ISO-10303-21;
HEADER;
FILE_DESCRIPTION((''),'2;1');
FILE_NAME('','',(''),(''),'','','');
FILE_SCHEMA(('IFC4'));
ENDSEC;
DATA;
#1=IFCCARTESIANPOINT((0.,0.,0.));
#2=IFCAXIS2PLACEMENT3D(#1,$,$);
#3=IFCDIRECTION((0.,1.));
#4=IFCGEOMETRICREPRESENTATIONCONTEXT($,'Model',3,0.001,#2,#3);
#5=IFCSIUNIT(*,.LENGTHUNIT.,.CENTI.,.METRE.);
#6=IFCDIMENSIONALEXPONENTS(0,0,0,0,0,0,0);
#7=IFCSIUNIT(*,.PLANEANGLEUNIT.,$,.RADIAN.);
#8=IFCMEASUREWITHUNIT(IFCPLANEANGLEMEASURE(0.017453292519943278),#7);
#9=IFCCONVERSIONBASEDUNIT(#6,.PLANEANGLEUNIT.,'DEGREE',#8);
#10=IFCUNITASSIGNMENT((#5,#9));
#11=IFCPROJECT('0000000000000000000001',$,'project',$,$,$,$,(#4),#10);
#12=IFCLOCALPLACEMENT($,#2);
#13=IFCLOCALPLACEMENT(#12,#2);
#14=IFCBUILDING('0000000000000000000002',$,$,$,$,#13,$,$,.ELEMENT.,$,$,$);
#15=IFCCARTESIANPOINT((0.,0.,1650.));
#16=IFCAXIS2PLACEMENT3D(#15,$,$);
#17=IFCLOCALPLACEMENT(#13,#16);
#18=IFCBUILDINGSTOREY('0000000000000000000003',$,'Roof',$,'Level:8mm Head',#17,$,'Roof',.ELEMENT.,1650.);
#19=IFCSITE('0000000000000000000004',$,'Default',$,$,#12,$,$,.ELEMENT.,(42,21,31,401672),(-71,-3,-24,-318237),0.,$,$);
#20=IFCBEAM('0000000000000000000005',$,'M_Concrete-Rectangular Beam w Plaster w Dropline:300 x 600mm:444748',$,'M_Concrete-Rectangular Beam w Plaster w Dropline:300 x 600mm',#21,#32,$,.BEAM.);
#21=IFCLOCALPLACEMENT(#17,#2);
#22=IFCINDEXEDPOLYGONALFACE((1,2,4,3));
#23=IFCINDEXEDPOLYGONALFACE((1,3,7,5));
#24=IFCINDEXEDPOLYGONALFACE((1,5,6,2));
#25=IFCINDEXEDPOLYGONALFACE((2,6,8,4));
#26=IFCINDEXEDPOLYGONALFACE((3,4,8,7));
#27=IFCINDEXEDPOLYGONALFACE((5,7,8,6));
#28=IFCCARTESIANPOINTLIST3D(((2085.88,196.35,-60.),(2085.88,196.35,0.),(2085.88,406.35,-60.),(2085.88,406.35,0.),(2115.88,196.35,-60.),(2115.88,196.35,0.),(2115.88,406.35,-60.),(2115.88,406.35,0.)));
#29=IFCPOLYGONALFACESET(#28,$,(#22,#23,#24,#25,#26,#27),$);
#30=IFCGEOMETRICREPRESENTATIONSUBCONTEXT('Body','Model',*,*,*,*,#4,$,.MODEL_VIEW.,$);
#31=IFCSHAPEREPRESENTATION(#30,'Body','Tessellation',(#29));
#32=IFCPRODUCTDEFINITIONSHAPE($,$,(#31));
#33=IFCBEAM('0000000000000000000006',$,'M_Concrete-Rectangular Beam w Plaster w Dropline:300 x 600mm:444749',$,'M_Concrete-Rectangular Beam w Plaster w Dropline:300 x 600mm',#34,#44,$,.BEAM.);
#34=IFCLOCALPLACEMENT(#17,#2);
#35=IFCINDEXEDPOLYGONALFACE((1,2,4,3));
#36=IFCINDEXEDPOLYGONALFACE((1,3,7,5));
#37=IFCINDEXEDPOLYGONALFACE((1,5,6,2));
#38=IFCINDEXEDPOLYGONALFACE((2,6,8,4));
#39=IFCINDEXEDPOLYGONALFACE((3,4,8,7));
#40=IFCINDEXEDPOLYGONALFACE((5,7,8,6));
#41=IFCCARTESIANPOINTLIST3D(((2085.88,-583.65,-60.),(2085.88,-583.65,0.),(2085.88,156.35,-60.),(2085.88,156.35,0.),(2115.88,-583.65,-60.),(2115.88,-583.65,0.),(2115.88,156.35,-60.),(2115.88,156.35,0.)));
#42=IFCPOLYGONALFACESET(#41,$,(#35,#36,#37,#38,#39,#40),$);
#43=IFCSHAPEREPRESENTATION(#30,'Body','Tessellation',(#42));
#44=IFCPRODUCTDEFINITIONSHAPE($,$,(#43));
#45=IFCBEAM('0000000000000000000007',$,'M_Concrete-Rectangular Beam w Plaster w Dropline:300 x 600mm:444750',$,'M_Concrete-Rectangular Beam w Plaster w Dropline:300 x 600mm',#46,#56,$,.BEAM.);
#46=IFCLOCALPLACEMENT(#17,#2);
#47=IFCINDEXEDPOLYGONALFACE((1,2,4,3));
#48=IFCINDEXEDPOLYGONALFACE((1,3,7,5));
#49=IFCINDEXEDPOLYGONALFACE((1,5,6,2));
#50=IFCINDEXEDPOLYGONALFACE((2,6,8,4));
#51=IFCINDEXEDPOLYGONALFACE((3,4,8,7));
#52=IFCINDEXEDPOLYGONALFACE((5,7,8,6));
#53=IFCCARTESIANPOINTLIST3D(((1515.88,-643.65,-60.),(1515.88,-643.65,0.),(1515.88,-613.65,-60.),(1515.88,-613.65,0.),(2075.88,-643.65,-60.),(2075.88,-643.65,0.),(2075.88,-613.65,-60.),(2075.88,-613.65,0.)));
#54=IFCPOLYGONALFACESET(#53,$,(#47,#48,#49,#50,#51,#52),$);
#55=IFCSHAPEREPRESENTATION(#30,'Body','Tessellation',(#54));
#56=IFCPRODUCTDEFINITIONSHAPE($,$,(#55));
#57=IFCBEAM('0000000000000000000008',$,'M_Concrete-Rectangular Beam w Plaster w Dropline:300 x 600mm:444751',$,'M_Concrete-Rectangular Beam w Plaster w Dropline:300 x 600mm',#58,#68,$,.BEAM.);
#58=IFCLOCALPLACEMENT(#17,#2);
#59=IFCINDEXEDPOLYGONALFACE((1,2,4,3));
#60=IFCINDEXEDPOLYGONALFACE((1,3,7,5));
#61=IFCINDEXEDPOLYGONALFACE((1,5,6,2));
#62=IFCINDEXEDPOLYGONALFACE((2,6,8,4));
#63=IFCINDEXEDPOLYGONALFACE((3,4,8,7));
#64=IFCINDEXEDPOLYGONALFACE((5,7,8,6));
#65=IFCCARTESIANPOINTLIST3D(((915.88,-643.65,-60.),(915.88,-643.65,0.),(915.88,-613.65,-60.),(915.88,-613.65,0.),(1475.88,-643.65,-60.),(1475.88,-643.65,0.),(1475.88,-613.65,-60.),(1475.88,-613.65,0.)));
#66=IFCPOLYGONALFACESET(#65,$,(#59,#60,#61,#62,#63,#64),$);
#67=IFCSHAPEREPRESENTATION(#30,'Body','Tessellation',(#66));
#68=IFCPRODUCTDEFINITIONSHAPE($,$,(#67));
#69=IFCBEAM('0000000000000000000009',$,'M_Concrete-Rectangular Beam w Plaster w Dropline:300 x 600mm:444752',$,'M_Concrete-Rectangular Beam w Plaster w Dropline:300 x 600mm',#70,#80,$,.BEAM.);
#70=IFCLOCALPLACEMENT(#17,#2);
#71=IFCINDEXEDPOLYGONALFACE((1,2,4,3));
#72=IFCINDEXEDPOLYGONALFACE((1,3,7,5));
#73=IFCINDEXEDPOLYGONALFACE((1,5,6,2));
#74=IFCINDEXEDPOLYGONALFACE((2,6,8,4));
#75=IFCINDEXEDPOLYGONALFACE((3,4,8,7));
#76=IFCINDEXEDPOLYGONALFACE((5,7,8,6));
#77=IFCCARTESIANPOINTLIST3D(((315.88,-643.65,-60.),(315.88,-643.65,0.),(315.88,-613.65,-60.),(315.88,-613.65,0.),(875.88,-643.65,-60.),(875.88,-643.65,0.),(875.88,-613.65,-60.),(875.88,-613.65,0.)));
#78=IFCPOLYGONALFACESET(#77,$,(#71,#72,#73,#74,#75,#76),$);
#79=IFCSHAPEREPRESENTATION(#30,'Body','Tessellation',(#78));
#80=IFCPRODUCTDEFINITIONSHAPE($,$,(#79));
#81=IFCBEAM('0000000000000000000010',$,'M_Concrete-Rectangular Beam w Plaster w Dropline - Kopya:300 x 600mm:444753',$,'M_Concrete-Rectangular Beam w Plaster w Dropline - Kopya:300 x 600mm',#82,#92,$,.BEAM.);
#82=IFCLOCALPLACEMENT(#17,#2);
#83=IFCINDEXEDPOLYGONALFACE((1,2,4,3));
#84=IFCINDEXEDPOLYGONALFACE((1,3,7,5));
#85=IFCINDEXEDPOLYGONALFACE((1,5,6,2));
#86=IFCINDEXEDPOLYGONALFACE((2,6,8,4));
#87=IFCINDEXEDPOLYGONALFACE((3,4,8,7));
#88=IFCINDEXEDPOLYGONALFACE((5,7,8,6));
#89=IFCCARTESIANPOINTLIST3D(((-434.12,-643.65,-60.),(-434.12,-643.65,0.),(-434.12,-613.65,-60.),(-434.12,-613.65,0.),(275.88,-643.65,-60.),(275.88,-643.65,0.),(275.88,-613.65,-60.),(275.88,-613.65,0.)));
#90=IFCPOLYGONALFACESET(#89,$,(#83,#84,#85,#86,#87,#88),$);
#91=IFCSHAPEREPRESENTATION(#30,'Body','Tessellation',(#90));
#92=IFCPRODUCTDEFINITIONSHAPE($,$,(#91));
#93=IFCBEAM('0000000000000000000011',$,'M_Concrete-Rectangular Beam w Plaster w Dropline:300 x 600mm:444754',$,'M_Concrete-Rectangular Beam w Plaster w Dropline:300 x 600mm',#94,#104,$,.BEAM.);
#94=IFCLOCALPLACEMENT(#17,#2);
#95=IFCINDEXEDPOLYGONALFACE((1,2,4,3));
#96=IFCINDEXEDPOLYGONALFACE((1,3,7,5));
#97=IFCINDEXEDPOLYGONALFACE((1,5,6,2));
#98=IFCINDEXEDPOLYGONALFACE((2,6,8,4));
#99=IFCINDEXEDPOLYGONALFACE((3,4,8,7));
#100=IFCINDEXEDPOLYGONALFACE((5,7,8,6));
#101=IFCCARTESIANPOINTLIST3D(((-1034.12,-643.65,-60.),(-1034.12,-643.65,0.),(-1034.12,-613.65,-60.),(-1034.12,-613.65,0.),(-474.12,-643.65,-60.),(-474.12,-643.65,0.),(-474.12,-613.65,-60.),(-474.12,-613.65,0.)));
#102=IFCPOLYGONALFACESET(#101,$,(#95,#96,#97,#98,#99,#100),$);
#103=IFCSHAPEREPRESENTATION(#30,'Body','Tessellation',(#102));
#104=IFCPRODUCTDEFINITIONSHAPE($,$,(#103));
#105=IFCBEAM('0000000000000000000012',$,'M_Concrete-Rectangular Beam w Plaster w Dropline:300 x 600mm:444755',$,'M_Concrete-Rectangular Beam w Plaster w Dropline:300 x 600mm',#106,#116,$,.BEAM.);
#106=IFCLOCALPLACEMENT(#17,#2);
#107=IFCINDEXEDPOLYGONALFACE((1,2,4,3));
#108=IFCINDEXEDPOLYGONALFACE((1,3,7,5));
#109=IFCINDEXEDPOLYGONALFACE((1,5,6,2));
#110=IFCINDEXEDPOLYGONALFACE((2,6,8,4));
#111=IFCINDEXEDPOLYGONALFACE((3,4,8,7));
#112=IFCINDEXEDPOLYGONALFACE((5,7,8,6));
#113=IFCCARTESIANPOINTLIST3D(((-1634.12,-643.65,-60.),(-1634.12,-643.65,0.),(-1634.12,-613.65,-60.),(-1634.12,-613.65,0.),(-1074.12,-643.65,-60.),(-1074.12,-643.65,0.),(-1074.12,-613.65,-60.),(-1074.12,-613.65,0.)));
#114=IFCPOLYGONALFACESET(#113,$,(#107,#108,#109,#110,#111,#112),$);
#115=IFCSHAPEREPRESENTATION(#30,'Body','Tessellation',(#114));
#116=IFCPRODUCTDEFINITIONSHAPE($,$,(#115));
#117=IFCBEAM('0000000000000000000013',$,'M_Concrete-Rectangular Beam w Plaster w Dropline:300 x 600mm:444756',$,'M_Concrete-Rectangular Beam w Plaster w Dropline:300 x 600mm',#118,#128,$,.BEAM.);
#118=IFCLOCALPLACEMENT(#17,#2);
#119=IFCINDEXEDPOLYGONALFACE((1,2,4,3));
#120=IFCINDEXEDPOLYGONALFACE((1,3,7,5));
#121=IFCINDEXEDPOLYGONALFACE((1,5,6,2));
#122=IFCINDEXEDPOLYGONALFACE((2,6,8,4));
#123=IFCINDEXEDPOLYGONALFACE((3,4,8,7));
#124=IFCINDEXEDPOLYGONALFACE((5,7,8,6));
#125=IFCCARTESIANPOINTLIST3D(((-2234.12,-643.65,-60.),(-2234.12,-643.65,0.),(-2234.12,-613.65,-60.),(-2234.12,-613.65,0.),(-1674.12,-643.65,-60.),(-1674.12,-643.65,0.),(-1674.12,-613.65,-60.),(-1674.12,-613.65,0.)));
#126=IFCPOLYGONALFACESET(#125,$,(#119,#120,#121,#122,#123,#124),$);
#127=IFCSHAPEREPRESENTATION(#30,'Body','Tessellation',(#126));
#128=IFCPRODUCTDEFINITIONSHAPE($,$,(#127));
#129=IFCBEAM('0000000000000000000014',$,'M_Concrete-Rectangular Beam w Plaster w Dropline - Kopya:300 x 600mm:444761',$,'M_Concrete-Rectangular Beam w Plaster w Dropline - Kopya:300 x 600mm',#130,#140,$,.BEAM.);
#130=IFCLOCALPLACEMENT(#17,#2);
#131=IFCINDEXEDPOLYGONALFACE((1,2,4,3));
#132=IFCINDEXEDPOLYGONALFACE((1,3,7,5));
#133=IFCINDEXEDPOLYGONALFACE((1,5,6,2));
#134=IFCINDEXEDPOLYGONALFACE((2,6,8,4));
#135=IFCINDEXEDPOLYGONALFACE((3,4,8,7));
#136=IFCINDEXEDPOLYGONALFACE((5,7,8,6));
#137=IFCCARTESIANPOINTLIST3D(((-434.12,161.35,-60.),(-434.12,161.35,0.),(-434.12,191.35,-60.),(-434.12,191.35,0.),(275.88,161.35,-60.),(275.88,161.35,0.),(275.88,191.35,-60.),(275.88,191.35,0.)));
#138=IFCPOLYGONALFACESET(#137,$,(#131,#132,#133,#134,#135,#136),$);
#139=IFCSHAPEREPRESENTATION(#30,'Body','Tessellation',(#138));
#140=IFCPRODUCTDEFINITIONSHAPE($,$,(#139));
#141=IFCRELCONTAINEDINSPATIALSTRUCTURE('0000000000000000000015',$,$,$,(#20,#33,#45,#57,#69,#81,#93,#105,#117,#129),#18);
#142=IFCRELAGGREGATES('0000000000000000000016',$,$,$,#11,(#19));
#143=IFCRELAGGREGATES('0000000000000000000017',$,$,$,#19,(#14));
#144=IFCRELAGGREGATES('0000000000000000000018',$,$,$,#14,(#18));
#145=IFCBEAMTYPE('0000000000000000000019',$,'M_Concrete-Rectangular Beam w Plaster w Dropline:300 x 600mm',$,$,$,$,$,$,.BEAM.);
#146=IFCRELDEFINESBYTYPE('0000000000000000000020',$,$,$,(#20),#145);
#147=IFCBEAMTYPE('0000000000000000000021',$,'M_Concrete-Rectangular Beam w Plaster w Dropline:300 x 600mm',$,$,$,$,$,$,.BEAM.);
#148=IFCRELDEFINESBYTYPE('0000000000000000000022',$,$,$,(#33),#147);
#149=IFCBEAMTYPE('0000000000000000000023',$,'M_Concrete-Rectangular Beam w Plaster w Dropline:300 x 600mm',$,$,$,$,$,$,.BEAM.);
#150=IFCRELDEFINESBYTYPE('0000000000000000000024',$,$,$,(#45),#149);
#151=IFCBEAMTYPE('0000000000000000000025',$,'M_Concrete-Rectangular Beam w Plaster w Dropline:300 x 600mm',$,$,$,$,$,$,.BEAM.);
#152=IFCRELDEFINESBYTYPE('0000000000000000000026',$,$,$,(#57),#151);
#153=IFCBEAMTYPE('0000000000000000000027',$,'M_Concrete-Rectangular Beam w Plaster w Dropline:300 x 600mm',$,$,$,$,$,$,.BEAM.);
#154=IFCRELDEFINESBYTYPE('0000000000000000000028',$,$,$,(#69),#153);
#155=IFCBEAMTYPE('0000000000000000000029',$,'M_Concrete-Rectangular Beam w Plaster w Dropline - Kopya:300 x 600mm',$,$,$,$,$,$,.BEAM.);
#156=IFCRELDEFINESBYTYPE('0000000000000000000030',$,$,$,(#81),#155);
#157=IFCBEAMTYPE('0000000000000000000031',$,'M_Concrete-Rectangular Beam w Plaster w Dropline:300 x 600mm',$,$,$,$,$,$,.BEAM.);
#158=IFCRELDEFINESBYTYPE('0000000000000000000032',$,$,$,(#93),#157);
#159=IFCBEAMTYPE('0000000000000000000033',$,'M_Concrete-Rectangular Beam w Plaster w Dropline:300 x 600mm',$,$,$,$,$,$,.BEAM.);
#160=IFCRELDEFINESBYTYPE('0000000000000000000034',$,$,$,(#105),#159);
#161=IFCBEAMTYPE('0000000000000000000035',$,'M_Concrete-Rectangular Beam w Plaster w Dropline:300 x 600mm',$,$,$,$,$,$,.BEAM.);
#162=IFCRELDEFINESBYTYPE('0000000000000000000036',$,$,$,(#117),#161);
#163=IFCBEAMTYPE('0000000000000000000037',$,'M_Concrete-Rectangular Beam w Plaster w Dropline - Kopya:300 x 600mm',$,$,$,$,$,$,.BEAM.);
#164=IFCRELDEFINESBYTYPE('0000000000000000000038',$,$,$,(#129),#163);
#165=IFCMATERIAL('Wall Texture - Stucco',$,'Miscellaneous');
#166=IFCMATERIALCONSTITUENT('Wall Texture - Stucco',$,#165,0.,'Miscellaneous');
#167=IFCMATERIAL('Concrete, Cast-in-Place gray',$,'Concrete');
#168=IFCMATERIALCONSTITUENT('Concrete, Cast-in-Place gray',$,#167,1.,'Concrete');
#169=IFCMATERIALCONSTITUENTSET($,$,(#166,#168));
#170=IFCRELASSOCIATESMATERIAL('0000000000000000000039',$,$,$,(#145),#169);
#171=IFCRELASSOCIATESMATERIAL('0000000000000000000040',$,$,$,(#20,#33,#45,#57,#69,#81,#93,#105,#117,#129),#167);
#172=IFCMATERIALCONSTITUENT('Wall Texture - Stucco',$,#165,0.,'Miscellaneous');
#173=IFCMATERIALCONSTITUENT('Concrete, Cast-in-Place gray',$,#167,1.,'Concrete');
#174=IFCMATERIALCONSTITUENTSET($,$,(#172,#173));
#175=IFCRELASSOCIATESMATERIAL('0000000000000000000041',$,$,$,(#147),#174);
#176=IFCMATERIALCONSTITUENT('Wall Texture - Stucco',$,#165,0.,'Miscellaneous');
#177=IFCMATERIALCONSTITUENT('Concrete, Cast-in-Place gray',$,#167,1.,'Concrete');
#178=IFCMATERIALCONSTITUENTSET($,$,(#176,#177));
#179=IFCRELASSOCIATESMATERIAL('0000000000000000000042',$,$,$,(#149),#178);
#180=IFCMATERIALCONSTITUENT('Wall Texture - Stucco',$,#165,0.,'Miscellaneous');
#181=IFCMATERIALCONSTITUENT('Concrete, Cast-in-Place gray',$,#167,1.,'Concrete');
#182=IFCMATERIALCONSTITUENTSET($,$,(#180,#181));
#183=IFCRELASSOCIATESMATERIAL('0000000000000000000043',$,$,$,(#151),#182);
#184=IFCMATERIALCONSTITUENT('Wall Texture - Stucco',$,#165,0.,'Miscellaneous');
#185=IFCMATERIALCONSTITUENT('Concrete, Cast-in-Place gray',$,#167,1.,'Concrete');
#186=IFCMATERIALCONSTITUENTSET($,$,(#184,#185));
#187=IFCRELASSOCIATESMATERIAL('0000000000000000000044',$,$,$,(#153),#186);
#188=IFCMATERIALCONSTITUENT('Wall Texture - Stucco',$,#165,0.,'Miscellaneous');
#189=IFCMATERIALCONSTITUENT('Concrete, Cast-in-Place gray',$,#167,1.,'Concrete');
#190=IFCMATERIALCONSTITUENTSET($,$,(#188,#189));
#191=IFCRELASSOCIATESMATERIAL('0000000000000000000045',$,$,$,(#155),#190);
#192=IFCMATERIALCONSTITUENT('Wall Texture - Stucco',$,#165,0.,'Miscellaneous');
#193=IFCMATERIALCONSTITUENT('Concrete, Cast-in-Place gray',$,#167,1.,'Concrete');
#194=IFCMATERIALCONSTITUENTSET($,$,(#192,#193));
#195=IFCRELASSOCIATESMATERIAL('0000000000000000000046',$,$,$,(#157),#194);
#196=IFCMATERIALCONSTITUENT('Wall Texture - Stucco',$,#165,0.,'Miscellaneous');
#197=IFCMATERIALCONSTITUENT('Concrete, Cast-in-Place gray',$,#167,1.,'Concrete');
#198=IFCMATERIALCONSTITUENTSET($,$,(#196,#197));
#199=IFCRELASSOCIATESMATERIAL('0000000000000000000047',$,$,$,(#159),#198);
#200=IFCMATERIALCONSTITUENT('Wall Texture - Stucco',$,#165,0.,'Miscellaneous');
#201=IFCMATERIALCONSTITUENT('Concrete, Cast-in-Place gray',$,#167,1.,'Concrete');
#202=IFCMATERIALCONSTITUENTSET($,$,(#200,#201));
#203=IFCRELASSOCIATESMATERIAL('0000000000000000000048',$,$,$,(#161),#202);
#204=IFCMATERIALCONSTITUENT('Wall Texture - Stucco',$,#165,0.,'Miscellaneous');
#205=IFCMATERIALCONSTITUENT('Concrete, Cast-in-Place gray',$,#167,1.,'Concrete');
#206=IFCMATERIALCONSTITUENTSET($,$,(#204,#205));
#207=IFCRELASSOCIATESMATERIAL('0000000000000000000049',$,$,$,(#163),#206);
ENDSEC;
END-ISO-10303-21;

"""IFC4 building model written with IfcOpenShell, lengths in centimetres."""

from ifc_helpers import new_model, entity, si_unit, converted_unit, direction, frame, origin, place, context, subcontext, project, spatial, indexed_curve, outline, extrude, source, transform, mapped, material, constituent, constituent_set, type_object, type_shapes, element, save


model = new_model("IFC4")

# Units and contexts
model_context = context("Model", 3, precision=0.001, world=origin(), true_north=direction((0.0, 1.0)))
body_context = subcontext(model_context, "Body", "Model", "MODEL_VIEW")
ifc_project = project(units=[si_unit("LENGTHUNIT", "METRE", prefix="CENTI"), converted_unit("PLANEANGLEUNIT", "DEGREE", entity("IfcPlaneAngleMeasure", 0.017453292519943278), si_unit("PLANEANGLEUNIT", "RADIAN"), dimensions=[0, 0, 0, 0, 0, 0, 0])], contexts=[model_context])

# Site, building, storey
site_placement = place(None, origin())
site = spatial("IfcSite", under=ifc_project, at=site_placement, Name="Default", CompositionType="ELEMENT", RefLatitude=(42, 21, 31, 401672), RefLongitude=(-71, -3, -24, -318237), RefElevation=0.0)
building_placement = place(site_placement, origin())
building = spatial("IfcBuilding", under=site, at=building_placement, CompositionType="ELEMENT")
storey_placement = place(building_placement, frame((0.0, 0.0, 1650.0)))
storey = spatial("IfcBuildingStorey", under=building, at=storey_placement, Name="Roof", ObjectType="Level:8mm Head", LongName="Roof", CompositionType="ELEMENT", Elevation=1650.0)

# Beams
ifc_material_1 = material(Name="Concrete, Cast-in-Place gray", Category="Concrete")
ifc_material_2 = material(Name="Wall Texture - Stucco", Category="Miscellaneous")
ifc_constituent_1 = constituent(ifc_material_2, Name="Wall Texture - Stucco", Category="Miscellaneous", fraction=0.0)
ifc_constituent_2 = constituent(ifc_material_1, Name="Concrete, Cast-in-Place gray", Category="Concrete", fraction=1.0)
ifc_constituent_set_1 = constituent_set(constituents=[ifc_constituent_1, ifc_constituent_2])
beam_type_1 = type_object("IfcBeamType", Name="M_Concrete-Rectangular Beam w Plaster w Dropline:300 x 600mm", PredefinedType="BEAM", material=ifc_constituent_set_1)
shared_shape_1 = source(origin(), body_context, "Body", "SweptSolid", [
    extrude(outline(indexed_curve([(-15.0, -30.0), (15.0, -30.0), (15.0, 30.0), (-15.0, 30.0), (-15.0, -30.0)], self_intersect=False)), frame((2100.88, 406.35, 1620.0), z_axis=(0.0, -1.0, 0.0), x_axis=(-1.0, 0.0, 0.0)), (0.0, 0.0, 1.0), 210.0),
])
type_shapes(beam_type_1, [shared_shape_1])
beam_1_placement = place(storey_placement, frame((0.0, 0.0, -1650.0)))
element("IfcBeam", 1, at=beam_1_placement, inside=storey, type_object=beam_type_1, material=ifc_material_1, Name="M_Concrete-Rectangular Beam w Plaster w Dropline:300 x 600mm:444748", ObjectType="M_Concrete-Rectangular Beam w Plaster w Dropline:300 x 600mm", PredefinedType="BEAM", context=body_context, shape_type="MappedRepresentation", body=[
    mapped(shared_shape_1, transform((0.0, 0.0, 0.0), scale=1.0)),
])
ifc_constituent_3 = constituent(ifc_material_2, Name="Wall Texture - Stucco", Category="Miscellaneous", fraction=0.0)
ifc_constituent_4 = constituent(ifc_material_1, Name="Concrete, Cast-in-Place gray", Category="Concrete", fraction=1.0)
ifc_constituent_set_2 = constituent_set(constituents=[ifc_constituent_3, ifc_constituent_4])
beam_type_2 = type_object("IfcBeamType", Name="M_Concrete-Rectangular Beam w Plaster w Dropline:300 x 600mm", PredefinedType="BEAM", material=ifc_constituent_set_2)
shared_shape_2 = source(origin(), body_context, "Body", "SweptSolid", [
    extrude(outline(indexed_curve([(-15.0, -30.0), (15.0, -30.0), (15.0, 30.0), (-15.0, 30.0), (-15.0, -30.0)], self_intersect=False)), frame((2100.88, 156.35, 1620.0), z_axis=(0.0, -1.0, 0.0), x_axis=(-1.0, 0.0, 0.0)), (0.0, 0.0, 1.0), 740.0),
])
type_shapes(beam_type_2, [shared_shape_2])
beam_2_placement = place(storey_placement, frame((0.0, 0.0, -1650.0)))
element("IfcBeam", 2, at=beam_2_placement, inside=storey, type_object=beam_type_2, material=ifc_material_1, Name="M_Concrete-Rectangular Beam w Plaster w Dropline:300 x 600mm:444749", ObjectType="M_Concrete-Rectangular Beam w Plaster w Dropline:300 x 600mm", PredefinedType="BEAM", context=body_context, shape_type="MappedRepresentation", body=[
    mapped(shared_shape_2, transform((0.0, 0.0, 0.0), scale=1.0)),
])
ifc_constituent_5 = constituent(ifc_material_2, Name="Wall Texture - Stucco", Category="Miscellaneous", fraction=0.0)
ifc_constituent_6 = constituent(ifc_material_1, Name="Concrete, Cast-in-Place gray", Category="Concrete", fraction=1.0)
ifc_constituent_set_3 = constituent_set(constituents=[ifc_constituent_5, ifc_constituent_6])
beam_type_3 = type_object("IfcBeamType", Name="M_Concrete-Rectangular Beam w Plaster w Dropline:300 x 600mm", PredefinedType="BEAM", material=ifc_constituent_set_3)
shared_shape_3 = source(origin(), body_context, "Body", "SweptSolid", [
    extrude(outline(indexed_curve([(-30.0, -15.0), (30.0, -15.0), (30.0, 15.0), (-30.0, 15.0), (-30.0, -15.0)], self_intersect=False)), frame((2075.88, -628.65, 1620.0), z_axis=(-1.0, 0.0, 0.0), x_axis=(0.0, 0.0, -1.0)), (0.0, 0.0, 1.0), 560.0),
])
type_shapes(beam_type_3, [shared_shape_3])
beam_3_placement = place(storey_placement, frame((0.0, 0.0, -1650.0)))
element("IfcBeam", 3, at=beam_3_placement, inside=storey, type_object=beam_type_3, material=ifc_material_1, Name="M_Concrete-Rectangular Beam w Plaster w Dropline:300 x 600mm:444750", ObjectType="M_Concrete-Rectangular Beam w Plaster w Dropline:300 x 600mm", PredefinedType="BEAM", context=body_context, shape_type="MappedRepresentation", body=[
    mapped(shared_shape_3, transform((0.0, 0.0, 0.0), scale=1.0)),
])
ifc_constituent_7 = constituent(ifc_material_2, Name="Wall Texture - Stucco", Category="Miscellaneous", fraction=0.0)
ifc_constituent_8 = constituent(ifc_material_1, Name="Concrete, Cast-in-Place gray", Category="Concrete", fraction=1.0)
ifc_constituent_set_4 = constituent_set(constituents=[ifc_constituent_7, ifc_constituent_8])
beam_type_4 = type_object("IfcBeamType", Name="M_Concrete-Rectangular Beam w Plaster w Dropline:300 x 600mm", PredefinedType="BEAM", material=ifc_constituent_set_4)
shared_shape_4 = source(origin(), body_context, "Body", "SweptSolid", [
    extrude(outline(indexed_curve([(-30.0, -15.0), (30.0, -15.0), (30.0, 15.0), (-30.0, 15.0), (-30.0, -15.0)], self_intersect=False)), frame((1475.88, -628.65, 1620.0), z_axis=(-1.0, 0.0, 0.0), x_axis=(0.0, 0.0, -1.0)), (0.0, 0.0, 1.0), 560.0),
])
type_shapes(beam_type_4, [shared_shape_4])
beam_4_placement = place(storey_placement, frame((0.0, 0.0, -1650.0)))
element("IfcBeam", 4, at=beam_4_placement, inside=storey, type_object=beam_type_4, material=ifc_material_1, Name="M_Concrete-Rectangular Beam w Plaster w Dropline:300 x 600mm:444751", ObjectType="M_Concrete-Rectangular Beam w Plaster w Dropline:300 x 600mm", PredefinedType="BEAM", context=body_context, shape_type="MappedRepresentation", body=[
    mapped(shared_shape_4, transform((0.0, 0.0, 0.0), scale=1.0)),
])
ifc_constituent_9 = constituent(ifc_material_2, Name="Wall Texture - Stucco", Category="Miscellaneous", fraction=0.0)
ifc_constituent_10 = constituent(ifc_material_1, Name="Concrete, Cast-in-Place gray", Category="Concrete", fraction=1.0)
ifc_constituent_set_5 = constituent_set(constituents=[ifc_constituent_9, ifc_constituent_10])
beam_type_5 = type_object("IfcBeamType", Name="M_Concrete-Rectangular Beam w Plaster w Dropline:300 x 600mm", PredefinedType="BEAM", material=ifc_constituent_set_5)
shared_shape_5 = source(origin(), body_context, "Body", "SweptSolid", [
    extrude(outline(indexed_curve([(-30.0, -15.0), (30.0, -15.0), (30.0, 15.0), (-30.0, 15.0), (-30.0, -15.0)], self_intersect=False)), frame((875.88, -628.65, 1620.0), z_axis=(-1.0, 0.0, 0.0), x_axis=(0.0, 0.0, -1.0)), (0.0, 0.0, 1.0), 560.0),
])
type_shapes(beam_type_5, [shared_shape_5])
beam_5_placement = place(storey_placement, frame((0.0, 0.0, -1650.0)))
element("IfcBeam", 5, at=beam_5_placement, inside=storey, type_object=beam_type_5, material=ifc_material_1, Name="M_Concrete-Rectangular Beam w Plaster w Dropline:300 x 600mm:444752", ObjectType="M_Concrete-Rectangular Beam w Plaster w Dropline:300 x 600mm", PredefinedType="BEAM", context=body_context, shape_type="MappedRepresentation", body=[
    mapped(shared_shape_5, transform((0.0, 0.0, 0.0), scale=1.0)),
])
ifc_constituent_11 = constituent(ifc_material_2, Name="Wall Texture - Stucco", Category="Miscellaneous", fraction=0.0)
ifc_constituent_12 = constituent(ifc_material_1, Name="Concrete, Cast-in-Place gray", Category="Concrete", fraction=1.0)
ifc_constituent_set_6 = constituent_set(constituents=[ifc_constituent_11, ifc_constituent_12])
beam_type_6 = type_object("IfcBeamType", Name="M_Concrete-Rectangular Beam w Plaster w Dropline - Kopya:300 x 600mm", PredefinedType="BEAM", material=ifc_constituent_set_6)
shared_shape_6 = source(origin(), body_context, "Body", "SweptSolid", [
    extrude(outline(indexed_curve([(-30.0, -15.0), (30.0, -15.0), (30.0, 15.0), (-30.0, 15.0), (-30.0, -15.0)], self_intersect=False)), frame((275.88, -628.65, 1620.0), z_axis=(-1.0, 0.0, 0.0), x_axis=(0.0, 0.0, -1.0)), (0.0, 0.0, 1.0), 710.0),
])
type_shapes(beam_type_6, [shared_shape_6])
beam_6_placement = place(storey_placement, frame((0.0, 0.0, -1650.0)))
element("IfcBeam", 6, at=beam_6_placement, inside=storey, type_object=beam_type_6, material=ifc_material_1, Name="M_Concrete-Rectangular Beam w Plaster w Dropline - Kopya:300 x 600mm:444753", ObjectType="M_Concrete-Rectangular Beam w Plaster w Dropline - Kopya:300 x 600mm", PredefinedType="BEAM", context=body_context, shape_type="MappedRepresentation", body=[
    mapped(shared_shape_6, transform((0.0, 0.0, 0.0), scale=1.0)),
])
ifc_constituent_13 = constituent(ifc_material_2, Name="Wall Texture - Stucco", Category="Miscellaneous", fraction=0.0)
ifc_constituent_14 = constituent(ifc_material_1, Name="Concrete, Cast-in-Place gray", Category="Concrete", fraction=1.0)
ifc_constituent_set_7 = constituent_set(constituents=[ifc_constituent_13, ifc_constituent_14])
beam_type_7 = type_object("IfcBeamType", Name="M_Concrete-Rectangular Beam w Plaster w Dropline:300 x 600mm", PredefinedType="BEAM", material=ifc_constituent_set_7)
shared_shape_7 = source(origin(), body_context, "Body", "SweptSolid", [
    extrude(outline(indexed_curve([(-30.0, -15.0), (30.0, -15.0), (30.0, 15.0), (-30.0, 15.0), (-30.0, -15.0)], self_intersect=False)), frame((-474.12, -628.65, 1620.0), z_axis=(-1.0, 0.0, 0.0), x_axis=(0.0, 0.0, -1.0)), (0.0, 0.0, 1.0), 560.0),
])
type_shapes(beam_type_7, [shared_shape_7])
beam_7_placement = place(storey_placement, frame((0.0, 0.0, -1650.0)))
element("IfcBeam", 7, at=beam_7_placement, inside=storey, type_object=beam_type_7, material=ifc_material_1, Name="M_Concrete-Rectangular Beam w Plaster w Dropline:300 x 600mm:444754", ObjectType="M_Concrete-Rectangular Beam w Plaster w Dropline:300 x 600mm", PredefinedType="BEAM", context=body_context, shape_type="MappedRepresentation", body=[
    mapped(shared_shape_7, transform((0.0, 0.0, 0.0), scale=1.0)),
])
ifc_constituent_15 = constituent(ifc_material_2, Name="Wall Texture - Stucco", Category="Miscellaneous", fraction=0.0)
ifc_constituent_16 = constituent(ifc_material_1, Name="Concrete, Cast-in-Place gray", Category="Concrete", fraction=1.0)
ifc_constituent_set_8 = constituent_set(constituents=[ifc_constituent_15, ifc_constituent_16])
beam_type_8 = type_object("IfcBeamType", Name="M_Concrete-Rectangular Beam w Plaster w Dropline:300 x 600mm", PredefinedType="BEAM", material=ifc_constituent_set_8)
shared_shape_8 = source(origin(), body_context, "Body", "SweptSolid", [
    extrude(outline(indexed_curve([(-30.0, -15.0), (30.0, -15.0), (30.0, 15.0), (-30.0, 15.0), (-30.0, -15.0)], self_intersect=False)), frame((-1074.12, -628.65, 1620.0), z_axis=(-1.0, 0.0, 0.0), x_axis=(0.0, 0.0, -1.0)), (0.0, 0.0, 1.0), 560.0),
])
type_shapes(beam_type_8, [shared_shape_8])
beam_8_placement = place(storey_placement, frame((0.0, 0.0, -1650.0)))
element("IfcBeam", 8, at=beam_8_placement, inside=storey, type_object=beam_type_8, material=ifc_material_1, Name="M_Concrete-Rectangular Beam w Plaster w Dropline:300 x 600mm:444755", ObjectType="M_Concrete-Rectangular Beam w Plaster w Dropline:300 x 600mm", PredefinedType="BEAM", context=body_context, shape_type="MappedRepresentation", body=[
    mapped(shared_shape_8, transform((0.0, 0.0, 0.0), scale=1.0)),
])
ifc_constituent_17 = constituent(ifc_material_2, Name="Wall Texture - Stucco", Category="Miscellaneous", fraction=0.0)
ifc_constituent_18 = constituent(ifc_material_1, Name="Concrete, Cast-in-Place gray", Category="Concrete", fraction=1.0)
ifc_constituent_set_9 = constituent_set(constituents=[ifc_constituent_17, ifc_constituent_18])
beam_type_9 = type_object("IfcBeamType", Name="M_Concrete-Rectangular Beam w Plaster w Dropline:300 x 600mm", PredefinedType="BEAM", material=ifc_constituent_set_9)
shared_shape_9 = source(origin(), body_context, "Body", "SweptSolid", [
    extrude(outline(indexed_curve([(-30.0, -15.0), (30.0, -15.0), (30.0, 15.0), (-30.0, 15.0), (-30.0, -15.0)], self_intersect=False)), frame((-1674.12, -628.65, 1620.0), z_axis=(-1.0, 0.0, 0.0), x_axis=(0.0, 0.0, -1.0)), (0.0, 0.0, 1.0), 560.0),
])
type_shapes(beam_type_9, [shared_shape_9])
beam_9_placement = place(storey_placement, frame((0.0, 0.0, -1650.0)))
element("IfcBeam", 9, at=beam_9_placement, inside=storey, type_object=beam_type_9, material=ifc_material_1, Name="M_Concrete-Rectangular Beam w Plaster w Dropline:300 x 600mm:444756", ObjectType="M_Concrete-Rectangular Beam w Plaster w Dropline:300 x 600mm", PredefinedType="BEAM", context=body_context, shape_type="MappedRepresentation", body=[
    mapped(shared_shape_9, transform((0.0, 0.0, 0.0), scale=1.0)),
])
ifc_constituent_19 = constituent(ifc_material_2, Name="Wall Texture - Stucco", Category="Miscellaneous", fraction=0.0)
ifc_constituent_20 = constituent(ifc_material_1, Name="Concrete, Cast-in-Place gray", Category="Concrete", fraction=1.0)
ifc_constituent_set_10 = constituent_set(constituents=[ifc_constituent_19, ifc_constituent_20])
beam_type_10 = type_object("IfcBeamType", Name="M_Concrete-Rectangular Beam w Plaster w Dropline - Kopya:300 x 600mm", PredefinedType="BEAM", material=ifc_constituent_set_10)
shared_shape_10 = source(origin(), body_context, "Body", "SweptSolid", [
    extrude(outline(indexed_curve([(-30.0, -15.0), (30.0, -15.0), (30.0, 15.0), (-30.0, 15.0), (-30.0, -15.0)], self_intersect=False)), frame((275.88, 176.35, 1620.0), z_axis=(-1.0, 0.0, 0.0), x_axis=(0.0, 0.0, -1.0)), (0.0, 0.0, 1.0), 710.0),
])
type_shapes(beam_type_10, [shared_shape_10])
beam_10_placement = place(storey_placement, frame((0.0, 0.0, -1650.0)))
element("IfcBeam", 10, at=beam_10_placement, inside=storey, type_object=beam_type_10, material=ifc_material_1, Name="M_Concrete-Rectangular Beam w Plaster w Dropline - Kopya:300 x 600mm:444761", ObjectType="M_Concrete-Rectangular Beam w Plaster w Dropline - Kopya:300 x 600mm", PredefinedType="BEAM", context=body_context, shape_type="MappedRepresentation", body=[
    mapped(shared_shape_10, transform((0.0, 0.0, 0.0), scale=1.0)),
])

save(model, "model.ifc")
